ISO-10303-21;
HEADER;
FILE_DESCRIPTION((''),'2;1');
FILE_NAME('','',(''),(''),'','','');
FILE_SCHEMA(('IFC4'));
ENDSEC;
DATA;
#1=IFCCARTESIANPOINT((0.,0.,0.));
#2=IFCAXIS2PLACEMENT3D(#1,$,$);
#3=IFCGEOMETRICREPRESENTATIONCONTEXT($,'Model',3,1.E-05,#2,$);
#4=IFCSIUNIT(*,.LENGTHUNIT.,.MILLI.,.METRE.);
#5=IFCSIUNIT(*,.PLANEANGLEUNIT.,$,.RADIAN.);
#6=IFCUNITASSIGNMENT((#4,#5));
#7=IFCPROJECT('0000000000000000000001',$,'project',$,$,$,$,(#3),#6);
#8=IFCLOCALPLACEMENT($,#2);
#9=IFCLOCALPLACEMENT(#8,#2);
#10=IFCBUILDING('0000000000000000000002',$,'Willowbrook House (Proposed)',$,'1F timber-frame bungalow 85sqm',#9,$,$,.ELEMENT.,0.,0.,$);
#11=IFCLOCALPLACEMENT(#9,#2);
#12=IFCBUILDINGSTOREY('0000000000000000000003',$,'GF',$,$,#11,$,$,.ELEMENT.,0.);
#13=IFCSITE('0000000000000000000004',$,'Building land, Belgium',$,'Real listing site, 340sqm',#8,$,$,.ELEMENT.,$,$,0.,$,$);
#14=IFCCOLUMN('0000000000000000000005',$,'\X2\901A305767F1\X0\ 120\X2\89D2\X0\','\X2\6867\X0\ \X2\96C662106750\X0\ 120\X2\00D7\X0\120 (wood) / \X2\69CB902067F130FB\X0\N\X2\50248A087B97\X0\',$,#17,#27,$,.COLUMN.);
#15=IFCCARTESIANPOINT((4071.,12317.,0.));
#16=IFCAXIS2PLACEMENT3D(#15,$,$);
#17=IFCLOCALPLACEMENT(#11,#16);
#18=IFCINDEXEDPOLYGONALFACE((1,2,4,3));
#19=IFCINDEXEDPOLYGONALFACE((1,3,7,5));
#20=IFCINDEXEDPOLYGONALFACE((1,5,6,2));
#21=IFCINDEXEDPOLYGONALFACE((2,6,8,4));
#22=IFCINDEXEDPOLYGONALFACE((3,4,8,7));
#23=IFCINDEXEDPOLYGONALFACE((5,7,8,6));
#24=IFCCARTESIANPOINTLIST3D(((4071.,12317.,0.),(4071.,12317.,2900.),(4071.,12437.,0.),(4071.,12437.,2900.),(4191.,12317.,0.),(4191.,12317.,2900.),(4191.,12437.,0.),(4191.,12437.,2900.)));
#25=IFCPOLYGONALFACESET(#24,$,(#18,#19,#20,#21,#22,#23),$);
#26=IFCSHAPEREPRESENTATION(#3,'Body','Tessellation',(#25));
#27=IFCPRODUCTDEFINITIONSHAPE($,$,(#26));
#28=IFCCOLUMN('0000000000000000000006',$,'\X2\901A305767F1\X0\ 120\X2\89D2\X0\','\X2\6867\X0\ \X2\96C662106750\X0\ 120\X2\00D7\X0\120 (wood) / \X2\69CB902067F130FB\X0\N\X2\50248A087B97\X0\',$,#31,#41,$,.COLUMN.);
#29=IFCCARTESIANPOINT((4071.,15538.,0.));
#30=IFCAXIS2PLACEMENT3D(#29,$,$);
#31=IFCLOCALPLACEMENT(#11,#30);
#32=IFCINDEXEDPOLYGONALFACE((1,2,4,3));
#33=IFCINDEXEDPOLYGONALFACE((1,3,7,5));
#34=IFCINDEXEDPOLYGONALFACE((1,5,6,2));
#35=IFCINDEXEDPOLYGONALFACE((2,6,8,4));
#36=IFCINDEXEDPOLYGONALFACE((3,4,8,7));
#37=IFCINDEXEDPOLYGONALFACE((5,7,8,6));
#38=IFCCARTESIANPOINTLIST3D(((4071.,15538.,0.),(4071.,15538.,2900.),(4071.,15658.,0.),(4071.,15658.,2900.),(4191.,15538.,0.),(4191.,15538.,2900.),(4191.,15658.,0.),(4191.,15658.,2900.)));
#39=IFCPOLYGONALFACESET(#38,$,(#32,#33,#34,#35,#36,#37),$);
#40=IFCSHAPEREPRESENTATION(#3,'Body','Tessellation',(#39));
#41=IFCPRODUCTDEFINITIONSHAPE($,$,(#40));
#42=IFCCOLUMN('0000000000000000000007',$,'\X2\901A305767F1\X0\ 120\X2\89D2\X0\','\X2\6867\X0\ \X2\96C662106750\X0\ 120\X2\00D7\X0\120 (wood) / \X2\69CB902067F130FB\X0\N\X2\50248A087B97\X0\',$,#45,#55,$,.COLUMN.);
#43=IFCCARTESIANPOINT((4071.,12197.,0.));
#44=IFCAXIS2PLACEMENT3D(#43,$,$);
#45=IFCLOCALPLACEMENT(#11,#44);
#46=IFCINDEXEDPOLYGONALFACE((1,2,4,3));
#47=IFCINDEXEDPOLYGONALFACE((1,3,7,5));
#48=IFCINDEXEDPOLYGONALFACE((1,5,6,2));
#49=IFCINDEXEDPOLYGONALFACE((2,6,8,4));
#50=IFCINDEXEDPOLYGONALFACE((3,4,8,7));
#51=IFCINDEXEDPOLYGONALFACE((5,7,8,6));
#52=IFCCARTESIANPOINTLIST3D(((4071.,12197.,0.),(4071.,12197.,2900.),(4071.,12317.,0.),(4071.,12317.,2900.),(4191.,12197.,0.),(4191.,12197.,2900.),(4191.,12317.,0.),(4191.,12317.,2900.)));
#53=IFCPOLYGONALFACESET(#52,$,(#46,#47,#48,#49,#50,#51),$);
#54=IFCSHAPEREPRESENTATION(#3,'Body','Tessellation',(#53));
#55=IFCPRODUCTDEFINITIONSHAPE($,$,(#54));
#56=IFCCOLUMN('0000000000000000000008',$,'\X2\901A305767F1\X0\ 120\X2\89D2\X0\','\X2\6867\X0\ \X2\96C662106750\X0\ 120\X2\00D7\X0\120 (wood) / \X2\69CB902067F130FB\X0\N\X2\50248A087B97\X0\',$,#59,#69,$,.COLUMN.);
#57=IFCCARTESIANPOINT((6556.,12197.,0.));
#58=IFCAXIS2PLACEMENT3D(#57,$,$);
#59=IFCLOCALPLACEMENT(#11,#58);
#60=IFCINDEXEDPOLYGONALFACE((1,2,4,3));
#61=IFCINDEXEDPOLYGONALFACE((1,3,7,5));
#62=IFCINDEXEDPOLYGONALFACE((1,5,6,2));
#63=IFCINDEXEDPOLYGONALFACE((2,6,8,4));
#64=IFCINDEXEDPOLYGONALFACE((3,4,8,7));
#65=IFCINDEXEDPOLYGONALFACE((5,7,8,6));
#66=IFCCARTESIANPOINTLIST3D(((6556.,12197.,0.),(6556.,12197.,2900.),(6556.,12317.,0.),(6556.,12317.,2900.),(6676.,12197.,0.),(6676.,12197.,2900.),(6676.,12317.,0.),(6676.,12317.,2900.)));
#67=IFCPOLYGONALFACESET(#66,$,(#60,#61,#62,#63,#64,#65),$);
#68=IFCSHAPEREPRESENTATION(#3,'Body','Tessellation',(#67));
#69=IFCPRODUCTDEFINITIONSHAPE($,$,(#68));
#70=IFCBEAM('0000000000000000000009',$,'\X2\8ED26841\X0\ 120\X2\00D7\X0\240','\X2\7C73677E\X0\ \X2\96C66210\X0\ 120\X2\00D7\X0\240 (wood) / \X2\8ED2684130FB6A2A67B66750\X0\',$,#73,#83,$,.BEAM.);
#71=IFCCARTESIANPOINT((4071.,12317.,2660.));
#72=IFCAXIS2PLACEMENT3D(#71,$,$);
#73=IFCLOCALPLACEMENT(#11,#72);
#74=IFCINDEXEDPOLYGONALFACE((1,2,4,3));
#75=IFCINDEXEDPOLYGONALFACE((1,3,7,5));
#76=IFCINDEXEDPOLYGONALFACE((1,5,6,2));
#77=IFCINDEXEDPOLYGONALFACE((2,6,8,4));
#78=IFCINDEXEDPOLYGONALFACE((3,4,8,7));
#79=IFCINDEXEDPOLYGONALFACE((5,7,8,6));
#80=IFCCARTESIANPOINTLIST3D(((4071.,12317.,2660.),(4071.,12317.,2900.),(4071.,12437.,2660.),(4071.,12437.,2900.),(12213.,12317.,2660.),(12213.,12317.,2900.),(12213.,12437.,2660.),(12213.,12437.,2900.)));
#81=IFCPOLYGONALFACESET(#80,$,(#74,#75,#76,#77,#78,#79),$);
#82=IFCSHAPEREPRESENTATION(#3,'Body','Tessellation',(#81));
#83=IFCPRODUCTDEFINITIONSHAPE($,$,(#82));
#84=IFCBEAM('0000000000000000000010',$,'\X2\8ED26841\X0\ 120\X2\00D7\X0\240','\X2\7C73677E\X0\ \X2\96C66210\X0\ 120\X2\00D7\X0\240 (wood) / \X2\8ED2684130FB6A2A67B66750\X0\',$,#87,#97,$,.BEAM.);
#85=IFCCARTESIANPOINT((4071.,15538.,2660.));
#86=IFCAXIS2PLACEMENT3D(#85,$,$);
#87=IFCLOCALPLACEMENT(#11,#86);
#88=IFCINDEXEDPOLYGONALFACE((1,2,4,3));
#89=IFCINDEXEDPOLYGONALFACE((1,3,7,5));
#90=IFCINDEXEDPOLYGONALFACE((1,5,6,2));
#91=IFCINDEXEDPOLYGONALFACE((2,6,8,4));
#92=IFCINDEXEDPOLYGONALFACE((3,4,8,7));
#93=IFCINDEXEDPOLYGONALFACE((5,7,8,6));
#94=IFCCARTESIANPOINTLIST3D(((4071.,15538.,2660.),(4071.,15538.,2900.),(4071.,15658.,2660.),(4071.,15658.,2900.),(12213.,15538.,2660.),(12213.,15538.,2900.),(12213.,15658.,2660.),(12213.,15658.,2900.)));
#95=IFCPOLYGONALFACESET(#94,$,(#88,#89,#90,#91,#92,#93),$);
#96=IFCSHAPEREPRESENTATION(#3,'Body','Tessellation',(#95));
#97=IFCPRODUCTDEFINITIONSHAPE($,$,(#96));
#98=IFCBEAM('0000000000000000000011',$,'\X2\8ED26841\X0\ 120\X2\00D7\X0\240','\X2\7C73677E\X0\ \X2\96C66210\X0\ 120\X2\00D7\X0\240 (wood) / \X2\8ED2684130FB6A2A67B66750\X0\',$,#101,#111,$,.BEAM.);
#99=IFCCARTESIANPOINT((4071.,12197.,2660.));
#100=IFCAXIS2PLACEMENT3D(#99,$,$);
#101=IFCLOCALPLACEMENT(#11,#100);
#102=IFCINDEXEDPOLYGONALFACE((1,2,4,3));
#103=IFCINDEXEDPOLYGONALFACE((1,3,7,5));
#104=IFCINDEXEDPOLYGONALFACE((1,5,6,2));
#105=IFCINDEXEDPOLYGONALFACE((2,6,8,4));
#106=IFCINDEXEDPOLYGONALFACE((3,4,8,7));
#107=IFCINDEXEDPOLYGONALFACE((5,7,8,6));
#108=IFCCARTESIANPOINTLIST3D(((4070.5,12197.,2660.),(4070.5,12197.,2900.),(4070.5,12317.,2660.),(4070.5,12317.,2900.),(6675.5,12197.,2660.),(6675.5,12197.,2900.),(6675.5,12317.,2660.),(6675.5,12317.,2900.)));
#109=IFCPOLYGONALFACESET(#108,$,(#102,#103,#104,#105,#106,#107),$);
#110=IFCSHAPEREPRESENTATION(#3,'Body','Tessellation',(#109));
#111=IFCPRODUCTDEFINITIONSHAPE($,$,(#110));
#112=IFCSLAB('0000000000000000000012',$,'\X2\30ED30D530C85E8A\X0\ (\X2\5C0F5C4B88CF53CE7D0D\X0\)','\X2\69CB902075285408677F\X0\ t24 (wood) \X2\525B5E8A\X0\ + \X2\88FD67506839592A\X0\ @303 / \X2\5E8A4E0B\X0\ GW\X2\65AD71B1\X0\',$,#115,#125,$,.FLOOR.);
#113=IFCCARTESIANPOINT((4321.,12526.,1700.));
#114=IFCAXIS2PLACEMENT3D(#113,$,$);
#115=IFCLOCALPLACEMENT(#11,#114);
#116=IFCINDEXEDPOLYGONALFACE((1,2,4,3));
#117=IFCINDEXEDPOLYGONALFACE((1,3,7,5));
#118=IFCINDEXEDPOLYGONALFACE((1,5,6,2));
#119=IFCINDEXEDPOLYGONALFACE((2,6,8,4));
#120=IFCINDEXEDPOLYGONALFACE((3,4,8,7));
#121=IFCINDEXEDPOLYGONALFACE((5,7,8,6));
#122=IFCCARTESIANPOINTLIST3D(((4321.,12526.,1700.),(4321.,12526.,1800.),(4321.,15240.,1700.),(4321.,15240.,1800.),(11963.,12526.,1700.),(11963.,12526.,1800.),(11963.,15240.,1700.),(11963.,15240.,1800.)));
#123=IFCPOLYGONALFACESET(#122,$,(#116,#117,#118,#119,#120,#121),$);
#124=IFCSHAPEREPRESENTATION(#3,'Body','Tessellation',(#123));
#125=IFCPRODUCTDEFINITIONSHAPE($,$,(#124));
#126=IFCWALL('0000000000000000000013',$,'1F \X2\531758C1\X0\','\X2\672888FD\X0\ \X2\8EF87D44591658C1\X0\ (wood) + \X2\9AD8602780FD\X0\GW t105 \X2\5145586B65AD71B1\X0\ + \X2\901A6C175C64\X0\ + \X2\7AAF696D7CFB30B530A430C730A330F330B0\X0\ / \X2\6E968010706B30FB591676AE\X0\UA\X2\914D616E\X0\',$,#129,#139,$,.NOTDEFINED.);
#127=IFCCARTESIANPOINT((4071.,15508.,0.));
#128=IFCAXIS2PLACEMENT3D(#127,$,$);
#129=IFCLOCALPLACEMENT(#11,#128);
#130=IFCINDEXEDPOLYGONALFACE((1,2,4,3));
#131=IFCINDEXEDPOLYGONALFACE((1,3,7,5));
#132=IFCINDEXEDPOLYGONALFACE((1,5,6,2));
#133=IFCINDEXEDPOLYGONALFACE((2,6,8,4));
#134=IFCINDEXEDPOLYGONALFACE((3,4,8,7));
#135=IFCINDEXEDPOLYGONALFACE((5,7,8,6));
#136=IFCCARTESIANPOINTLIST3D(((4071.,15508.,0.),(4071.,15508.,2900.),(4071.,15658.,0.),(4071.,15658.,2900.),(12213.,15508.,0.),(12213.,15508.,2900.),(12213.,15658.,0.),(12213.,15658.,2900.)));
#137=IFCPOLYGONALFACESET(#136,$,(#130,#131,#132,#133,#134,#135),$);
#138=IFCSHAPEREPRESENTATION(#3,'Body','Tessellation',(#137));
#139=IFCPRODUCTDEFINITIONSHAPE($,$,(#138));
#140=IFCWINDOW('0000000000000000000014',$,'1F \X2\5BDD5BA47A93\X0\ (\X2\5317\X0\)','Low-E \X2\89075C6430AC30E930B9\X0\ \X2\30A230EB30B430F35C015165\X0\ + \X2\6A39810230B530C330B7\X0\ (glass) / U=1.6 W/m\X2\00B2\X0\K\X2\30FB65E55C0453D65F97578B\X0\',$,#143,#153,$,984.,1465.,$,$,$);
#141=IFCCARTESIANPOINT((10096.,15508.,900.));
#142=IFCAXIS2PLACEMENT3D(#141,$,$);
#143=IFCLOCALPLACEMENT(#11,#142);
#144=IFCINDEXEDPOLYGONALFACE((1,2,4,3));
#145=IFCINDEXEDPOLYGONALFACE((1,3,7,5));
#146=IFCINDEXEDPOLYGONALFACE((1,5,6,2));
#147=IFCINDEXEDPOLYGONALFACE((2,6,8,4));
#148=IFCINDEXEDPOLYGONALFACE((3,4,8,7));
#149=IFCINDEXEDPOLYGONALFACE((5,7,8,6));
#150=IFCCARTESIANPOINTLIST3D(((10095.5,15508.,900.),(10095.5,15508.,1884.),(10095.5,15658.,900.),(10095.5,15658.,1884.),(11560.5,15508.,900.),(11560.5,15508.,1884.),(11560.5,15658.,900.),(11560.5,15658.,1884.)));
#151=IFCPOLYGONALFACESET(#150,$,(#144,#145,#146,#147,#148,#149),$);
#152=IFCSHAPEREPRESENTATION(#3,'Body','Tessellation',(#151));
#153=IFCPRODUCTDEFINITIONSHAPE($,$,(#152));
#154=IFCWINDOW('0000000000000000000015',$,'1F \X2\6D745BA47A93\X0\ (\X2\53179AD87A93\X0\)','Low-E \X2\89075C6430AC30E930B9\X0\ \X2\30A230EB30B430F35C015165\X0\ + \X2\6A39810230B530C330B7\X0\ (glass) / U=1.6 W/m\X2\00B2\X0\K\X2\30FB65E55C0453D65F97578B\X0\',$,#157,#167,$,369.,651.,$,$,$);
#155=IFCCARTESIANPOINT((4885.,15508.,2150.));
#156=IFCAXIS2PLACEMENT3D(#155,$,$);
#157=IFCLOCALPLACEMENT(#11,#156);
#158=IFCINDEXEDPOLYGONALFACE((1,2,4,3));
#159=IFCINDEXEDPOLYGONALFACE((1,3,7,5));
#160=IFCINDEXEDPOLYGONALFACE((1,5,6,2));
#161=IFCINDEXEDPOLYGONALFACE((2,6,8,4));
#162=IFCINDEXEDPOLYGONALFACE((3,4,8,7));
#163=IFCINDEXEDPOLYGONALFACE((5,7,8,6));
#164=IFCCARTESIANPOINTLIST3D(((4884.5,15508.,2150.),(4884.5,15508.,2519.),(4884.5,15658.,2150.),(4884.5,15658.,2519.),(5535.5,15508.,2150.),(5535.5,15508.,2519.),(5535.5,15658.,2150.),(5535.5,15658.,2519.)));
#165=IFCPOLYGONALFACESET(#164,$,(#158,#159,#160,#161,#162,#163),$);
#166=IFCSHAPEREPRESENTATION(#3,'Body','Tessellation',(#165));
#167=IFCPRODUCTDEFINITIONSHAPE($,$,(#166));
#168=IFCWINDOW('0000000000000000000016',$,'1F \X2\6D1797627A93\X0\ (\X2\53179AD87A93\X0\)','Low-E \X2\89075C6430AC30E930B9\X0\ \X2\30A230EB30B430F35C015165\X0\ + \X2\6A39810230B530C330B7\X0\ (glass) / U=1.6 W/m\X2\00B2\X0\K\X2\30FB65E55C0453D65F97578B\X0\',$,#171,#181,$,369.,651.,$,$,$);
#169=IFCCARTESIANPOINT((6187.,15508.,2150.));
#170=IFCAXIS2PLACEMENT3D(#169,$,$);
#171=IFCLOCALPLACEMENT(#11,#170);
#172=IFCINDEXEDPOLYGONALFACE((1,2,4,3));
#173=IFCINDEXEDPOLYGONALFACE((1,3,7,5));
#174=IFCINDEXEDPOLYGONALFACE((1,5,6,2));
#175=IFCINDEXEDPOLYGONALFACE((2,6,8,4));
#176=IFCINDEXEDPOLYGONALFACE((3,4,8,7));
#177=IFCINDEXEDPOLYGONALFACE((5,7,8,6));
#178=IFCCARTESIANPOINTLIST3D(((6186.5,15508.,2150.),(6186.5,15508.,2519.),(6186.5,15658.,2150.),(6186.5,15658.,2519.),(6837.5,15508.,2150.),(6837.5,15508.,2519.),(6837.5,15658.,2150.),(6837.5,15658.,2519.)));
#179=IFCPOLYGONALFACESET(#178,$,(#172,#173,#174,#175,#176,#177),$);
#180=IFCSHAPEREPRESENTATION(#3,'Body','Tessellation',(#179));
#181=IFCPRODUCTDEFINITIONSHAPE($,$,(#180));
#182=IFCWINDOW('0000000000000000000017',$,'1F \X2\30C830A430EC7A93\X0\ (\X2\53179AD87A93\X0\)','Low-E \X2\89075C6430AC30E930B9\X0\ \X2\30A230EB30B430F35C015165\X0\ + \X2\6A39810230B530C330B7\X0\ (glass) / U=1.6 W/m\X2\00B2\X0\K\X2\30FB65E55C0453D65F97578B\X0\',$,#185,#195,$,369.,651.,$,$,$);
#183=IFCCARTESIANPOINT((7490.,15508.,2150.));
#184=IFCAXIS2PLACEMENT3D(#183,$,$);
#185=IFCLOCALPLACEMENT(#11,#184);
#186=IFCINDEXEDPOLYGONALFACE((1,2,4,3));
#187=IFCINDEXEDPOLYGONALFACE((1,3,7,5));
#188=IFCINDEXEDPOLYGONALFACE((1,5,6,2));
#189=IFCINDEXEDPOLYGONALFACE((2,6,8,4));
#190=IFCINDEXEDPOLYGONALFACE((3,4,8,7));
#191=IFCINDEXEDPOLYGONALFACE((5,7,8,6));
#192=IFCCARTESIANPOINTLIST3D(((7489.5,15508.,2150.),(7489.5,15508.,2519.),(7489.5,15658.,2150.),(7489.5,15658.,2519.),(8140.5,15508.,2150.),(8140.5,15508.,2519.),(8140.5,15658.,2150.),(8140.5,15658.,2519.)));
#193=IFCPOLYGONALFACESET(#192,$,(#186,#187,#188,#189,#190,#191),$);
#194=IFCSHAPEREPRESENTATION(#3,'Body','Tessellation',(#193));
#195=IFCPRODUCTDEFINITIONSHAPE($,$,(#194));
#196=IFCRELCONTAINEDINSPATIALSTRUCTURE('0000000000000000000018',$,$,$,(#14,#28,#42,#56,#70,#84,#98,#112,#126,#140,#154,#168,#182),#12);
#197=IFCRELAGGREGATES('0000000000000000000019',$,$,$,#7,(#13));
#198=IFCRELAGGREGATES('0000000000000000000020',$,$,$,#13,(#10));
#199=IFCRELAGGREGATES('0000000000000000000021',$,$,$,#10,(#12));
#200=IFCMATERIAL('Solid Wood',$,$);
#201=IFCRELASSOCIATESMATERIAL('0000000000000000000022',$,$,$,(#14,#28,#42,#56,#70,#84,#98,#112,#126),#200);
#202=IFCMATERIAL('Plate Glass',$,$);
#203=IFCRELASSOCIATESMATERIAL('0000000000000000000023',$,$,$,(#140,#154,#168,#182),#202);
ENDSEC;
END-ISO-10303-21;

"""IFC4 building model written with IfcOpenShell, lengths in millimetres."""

from ifc_helpers import new_model, si_unit, frame, frame_2d, origin, place, context, project, spatial, rectangle, extrude, material, element, fill, save


model = new_model("IFC4")

# Units and contexts
model_context = context("Model", 3, precision=1e-05, world=origin())
ifc_project = project(units=[si_unit("LENGTHUNIT", "METRE", prefix="MILLI"), si_unit("PLANEANGLEUNIT", "RADIAN")], contexts=[model_context])

# Site, building, storey
site_placement = place(None, origin())
site = spatial("IfcSite", under=ifc_project, at=site_placement, Name="Building land, Belgium", ObjectType="Real listing site, 340sqm", CompositionType="ELEMENT", RefElevation=0.0)
building_placement = place(site_placement, origin())
building = spatial("IfcBuilding", under=site, at=building_placement, Name="Willowbrook House (Proposed)", ObjectType="1F timber-frame bungalow 85sqm", CompositionType="ELEMENT", ElevationOfRefHeight=0.0, ElevationOfTerrain=0.0)
storey_placement = place(building_placement, origin())
storey = spatial("IfcBuildingStorey", under=building, at=storey_placement, Name="GF", CompositionType="ELEMENT", Elevation=0.0)

# Columns
ifc_material_1 = material(Name="Solid Wood")
column_1_placement = place(storey_placement, frame((4071.0, 12317.0, 0.0)))
element("IfcColumn", 1, at=column_1_placement, inside=storey, material=ifc_material_1, Name="通し柱 120角", Description="桧 集成材 120×120 (wood) / 構造柱・N値計算", PredefinedType="COLUMN", context=model_context, shape_type="SweptSolid", body=[
    extrude(rectangle(XDim=120.0, YDim=120.0, at=frame_2d((60.0, 60.0))), frame((4071.0, 12317.0, 0.0)), (0.0, 0.0, 1.0), 2900.0),
])
column_2_placement = place(storey_placement, frame((4071.0, 15538.0, 0.0)))
element("IfcColumn", 2, at=column_2_placement, inside=storey, material=ifc_material_1, Name="通し柱 120角", Description="桧 集成材 120×120 (wood) / 構造柱・N値計算", PredefinedType="COLUMN", context=model_context, shape_type="SweptSolid", body=[
    extrude(rectangle(XDim=120.0, YDim=120.0, at=frame_2d((60.0, 60.0))), frame((4071.0, 15538.0, 0.0)), (0.0, 0.0, 1.0), 2900.0),
])
column_3_placement = place(storey_placement, frame((4071.0, 12197.0, 0.0)))
element("IfcColumn", 3, at=column_3_placement, inside=storey, material=ifc_material_1, Name="通し柱 120角", Description="桧 集成材 120×120 (wood) / 構造柱・N値計算", PredefinedType="COLUMN", context=model_context, shape_type="SweptSolid", body=[
    extrude(rectangle(XDim=120.0, YDim=120.0, at=frame_2d((60.0, 60.0))), frame((4071.0, 12197.0, 0.0)), (0.0, 0.0, 1.0), 2900.0),
])
column_4_placement = place(storey_placement, frame((6556.0, 12197.0, 0.0)))
element("IfcColumn", 4, at=column_4_placement, inside=storey, material=ifc_material_1, Name="通し柱 120角", Description="桧 集成材 120×120 (wood) / 構造柱・N値計算", PredefinedType="COLUMN", context=model_context, shape_type="SweptSolid", body=[
    extrude(rectangle(XDim=120.0, YDim=120.0, at=frame_2d((60.0, 60.0))), frame((6556.0, 12197.0, 0.0)), (0.0, 0.0, 1.0), 2900.0),
])

# Beams
beam_1_placement = place(storey_placement, frame((4071.0, 12317.0, 2660.0)))
element("IfcBeam", 5, at=beam_1_placement, inside=storey, material=ifc_material_1, Name="軒桁 120×240", Description="米松 集成 120×240 (wood) / 軒桁・横架材", PredefinedType="BEAM", context=model_context, shape_type="SweptSolid", body=[
    extrude(rectangle(XDim=8142.0, YDim=120.0, at=frame_2d((4071.0, 60.0))), frame((4071.0, 12317.0, 2660.0)), (0.0, 0.0, 1.0), 240.0),
])
beam_2_placement = place(storey_placement, frame((4071.0, 15538.0, 2660.0)))
element("IfcBeam", 6, at=beam_2_placement, inside=storey, material=ifc_material_1, Name="軒桁 120×240", Description="米松 集成 120×240 (wood) / 軒桁・横架材", PredefinedType="BEAM", context=model_context, shape_type="SweptSolid", body=[
    extrude(rectangle(XDim=8142.0, YDim=120.0, at=frame_2d((4071.0, 60.0))), frame((4071.0, 15538.0, 2660.0)), (0.0, 0.0, 1.0), 240.0),
])
beam_3_placement = place(storey_placement, frame((4071.0, 12197.0, 2660.0)))
element("IfcBeam", 7, at=beam_3_placement, inside=storey, material=ifc_material_1, Name="軒桁 120×240", Description="米松 集成 120×240 (wood) / 軒桁・横架材", PredefinedType="BEAM", context=model_context, shape_type="SweptSolid", body=[
    extrude(rectangle(XDim=2605.0, YDim=120.0, at=frame_2d((1302.0, 60.0))), frame((4071.0, 12197.0, 2660.0)), (0.0, 0.0, 1.0), 240.0),
])

# Slab
slab_1_placement = place(storey_placement, frame((4321.0, 12526.0, 1700.0)))
element("IfcSlab", 8, at=slab_1_placement, inside=storey, material=ifc_material_1, Name="ロフト床 (小屋裏収納)", Description="構造用合板 t24 (wood) 剛床 + 製材根太 @303 / 床下 GW断熱", PredefinedType="FLOOR", context=model_context, shape_type="SweptSolid", body=[
    extrude(rectangle(XDim=7642.0, YDim=2714.0, at=frame_2d((3821.0, 1357.0))), frame((4321.0, 12526.0, 1700.0)), (0.0, 0.0, 1.0), 100.0),
])

# Wall, openings, windows
wall_1_placement = place(storey_placement, frame((4071.0, 15508.0, 0.0)))
wall_1 = element("IfcWall", 9, at=wall_1_placement, inside=storey, material=ifc_material_1, Name="1F 北壁", Description="木製 軸組外壁 (wood) + 高性能GW t105 充填断熱 + 通気層 + 窯業系サイディング / 準耐火・外皮UA配慮", PredefinedType="NOTDEFINED", context=model_context, shape_type="SweptSolid", body=[
    extrude(rectangle(XDim=8142.0, YDim=150.0, at=frame_2d((4071.0, 75.0))), frame((4071.0, 15508.0, 0.0)), (0.0, 0.0, 1.0), 2900.0),
])
opening_1_placement = place(storey_placement, frame((10096.0, 15508.0, 900.0)))
opening_1 = element("IfcOpeningElement", 10, at=opening_1_placement, cuts=wall_1, PredefinedType="NOTDEFINED", context=model_context, shape_type="SweptSolid", body=[
    extrude(rectangle(XDim=1465.0, YDim=150.0, at=frame_2d((732.0, 75.0))), frame((10096.0, 15508.0, 900.0)), (0.0, 0.0, 1.0), 984.0),
])
opening_2_placement = place(storey_placement, frame((4885.0, 15508.0, 2150.0)))
opening_2 = element("IfcOpeningElement", 11, at=opening_2_placement, cuts=wall_1, PredefinedType="NOTDEFINED", context=model_context, shape_type="SweptSolid", body=[
    extrude(rectangle(XDim=651.0, YDim=150.0, at=frame_2d((325.0, 75.0))), frame((4885.0, 15508.0, 2150.0)), (0.0, 0.0, 1.0), 369.0),
])
opening_3_placement = place(storey_placement, frame((6187.0, 15508.0, 2150.0)))
opening_3 = element("IfcOpeningElement", 12, at=opening_3_placement, cuts=wall_1, PredefinedType="NOTDEFINED", context=model_context, shape_type="SweptSolid", body=[
    extrude(rectangle(XDim=651.0, YDim=150.0, at=frame_2d((325.0, 75.0))), frame((6187.0, 15508.0, 2150.0)), (0.0, 0.0, 1.0), 369.0),
])
opening_4_placement = place(storey_placement, frame((7490.0, 15508.0, 2150.0)))
opening_4 = element("IfcOpeningElement", 13, at=opening_4_placement, cuts=wall_1, PredefinedType="NOTDEFINED", context=model_context, shape_type="SweptSolid", body=[
    extrude(rectangle(XDim=651.0, YDim=150.0, at=frame_2d((325.0, 75.0))), frame((7490.0, 15508.0, 2150.0)), (0.0, 0.0, 1.0), 369.0),
])
ifc_material_2 = material(Name="Plate Glass")
window_1_placement = place(storey_placement, frame((10096.0, 15508.0, 900.0)))
window_1 = element("IfcWindow", 14, at=window_1_placement, inside=storey, material=ifc_material_2, Name="1F 寝室窓 (北)", Description="Low-E 複層ガラス アルゴン封入 + 樹脂サッシ (glass) / U=1.6 W/m²K・日射取得型", OverallHeight=984.0, OverallWidth=1465.0, context=model_context, shape_type="SweptSolid", body=[
    extrude(rectangle(XDim=1465.0, YDim=150.0, at=frame_2d((732.0, 75.0))), frame((10096.0, 15508.0, 900.0)), (0.0, 0.0, 1.0), 984.0),
])
fill(opening_1, window_1)
window_2_placement = place(storey_placement, frame((4885.0, 15508.0, 2150.0)))
window_2 = element("IfcWindow", 15, at=window_2_placement, inside=storey, material=ifc_material_2, Name="1F 浴室窓 (北高窓)", Description="Low-E 複層ガラス アルゴン封入 + 樹脂サッシ (glass) / U=1.6 W/m²K・日射取得型", OverallHeight=369.0, OverallWidth=651.0, context=model_context, shape_type="SweptSolid", body=[
    extrude(rectangle(XDim=651.0, YDim=150.0, at=frame_2d((325.0, 75.0))), frame((4885.0, 15508.0, 2150.0)), (0.0, 0.0, 1.0), 369.0),
])
fill(opening_2, window_2)
window_3_placement = place(storey_placement, frame((6187.0, 15508.0, 2150.0)))
window_3 = element("IfcWindow", 16, at=window_3_placement, inside=storey, material=ifc_material_2, Name="1F 洗面窓 (北高窓)", Description="Low-E 複層ガラス アルゴン封入 + 樹脂サッシ (glass) / U=1.6 W/m²K・日射取得型", OverallHeight=369.0, OverallWidth=651.0, context=model_context, shape_type="SweptSolid", body=[
    extrude(rectangle(XDim=651.0, YDim=150.0, at=frame_2d((325.0, 75.0))), frame((6187.0, 15508.0, 2150.0)), (0.0, 0.0, 1.0), 369.0),
])
fill(opening_3, window_3)
window_4_placement = place(storey_placement, frame((7490.0, 15508.0, 2150.0)))
window_4 = element("IfcWindow", 17, at=window_4_placement, inside=storey, material=ifc_material_2, Name="1F トイレ窓 (北高窓)", Description="Low-E 複層ガラス アルゴン封入 + 樹脂サッシ (glass) / U=1.6 W/m²K・日射取得型", OverallHeight=369.0, OverallWidth=651.0, context=model_context, shape_type="SweptSolid", body=[
    extrude(rectangle(XDim=651.0, YDim=150.0, at=frame_2d((325.0, 75.0))), frame((7490.0, 15508.0, 2150.0)), (0.0, 0.0, 1.0), 369.0),
])
fill(opening_4, window_4)

save(model, "model.ifc")
